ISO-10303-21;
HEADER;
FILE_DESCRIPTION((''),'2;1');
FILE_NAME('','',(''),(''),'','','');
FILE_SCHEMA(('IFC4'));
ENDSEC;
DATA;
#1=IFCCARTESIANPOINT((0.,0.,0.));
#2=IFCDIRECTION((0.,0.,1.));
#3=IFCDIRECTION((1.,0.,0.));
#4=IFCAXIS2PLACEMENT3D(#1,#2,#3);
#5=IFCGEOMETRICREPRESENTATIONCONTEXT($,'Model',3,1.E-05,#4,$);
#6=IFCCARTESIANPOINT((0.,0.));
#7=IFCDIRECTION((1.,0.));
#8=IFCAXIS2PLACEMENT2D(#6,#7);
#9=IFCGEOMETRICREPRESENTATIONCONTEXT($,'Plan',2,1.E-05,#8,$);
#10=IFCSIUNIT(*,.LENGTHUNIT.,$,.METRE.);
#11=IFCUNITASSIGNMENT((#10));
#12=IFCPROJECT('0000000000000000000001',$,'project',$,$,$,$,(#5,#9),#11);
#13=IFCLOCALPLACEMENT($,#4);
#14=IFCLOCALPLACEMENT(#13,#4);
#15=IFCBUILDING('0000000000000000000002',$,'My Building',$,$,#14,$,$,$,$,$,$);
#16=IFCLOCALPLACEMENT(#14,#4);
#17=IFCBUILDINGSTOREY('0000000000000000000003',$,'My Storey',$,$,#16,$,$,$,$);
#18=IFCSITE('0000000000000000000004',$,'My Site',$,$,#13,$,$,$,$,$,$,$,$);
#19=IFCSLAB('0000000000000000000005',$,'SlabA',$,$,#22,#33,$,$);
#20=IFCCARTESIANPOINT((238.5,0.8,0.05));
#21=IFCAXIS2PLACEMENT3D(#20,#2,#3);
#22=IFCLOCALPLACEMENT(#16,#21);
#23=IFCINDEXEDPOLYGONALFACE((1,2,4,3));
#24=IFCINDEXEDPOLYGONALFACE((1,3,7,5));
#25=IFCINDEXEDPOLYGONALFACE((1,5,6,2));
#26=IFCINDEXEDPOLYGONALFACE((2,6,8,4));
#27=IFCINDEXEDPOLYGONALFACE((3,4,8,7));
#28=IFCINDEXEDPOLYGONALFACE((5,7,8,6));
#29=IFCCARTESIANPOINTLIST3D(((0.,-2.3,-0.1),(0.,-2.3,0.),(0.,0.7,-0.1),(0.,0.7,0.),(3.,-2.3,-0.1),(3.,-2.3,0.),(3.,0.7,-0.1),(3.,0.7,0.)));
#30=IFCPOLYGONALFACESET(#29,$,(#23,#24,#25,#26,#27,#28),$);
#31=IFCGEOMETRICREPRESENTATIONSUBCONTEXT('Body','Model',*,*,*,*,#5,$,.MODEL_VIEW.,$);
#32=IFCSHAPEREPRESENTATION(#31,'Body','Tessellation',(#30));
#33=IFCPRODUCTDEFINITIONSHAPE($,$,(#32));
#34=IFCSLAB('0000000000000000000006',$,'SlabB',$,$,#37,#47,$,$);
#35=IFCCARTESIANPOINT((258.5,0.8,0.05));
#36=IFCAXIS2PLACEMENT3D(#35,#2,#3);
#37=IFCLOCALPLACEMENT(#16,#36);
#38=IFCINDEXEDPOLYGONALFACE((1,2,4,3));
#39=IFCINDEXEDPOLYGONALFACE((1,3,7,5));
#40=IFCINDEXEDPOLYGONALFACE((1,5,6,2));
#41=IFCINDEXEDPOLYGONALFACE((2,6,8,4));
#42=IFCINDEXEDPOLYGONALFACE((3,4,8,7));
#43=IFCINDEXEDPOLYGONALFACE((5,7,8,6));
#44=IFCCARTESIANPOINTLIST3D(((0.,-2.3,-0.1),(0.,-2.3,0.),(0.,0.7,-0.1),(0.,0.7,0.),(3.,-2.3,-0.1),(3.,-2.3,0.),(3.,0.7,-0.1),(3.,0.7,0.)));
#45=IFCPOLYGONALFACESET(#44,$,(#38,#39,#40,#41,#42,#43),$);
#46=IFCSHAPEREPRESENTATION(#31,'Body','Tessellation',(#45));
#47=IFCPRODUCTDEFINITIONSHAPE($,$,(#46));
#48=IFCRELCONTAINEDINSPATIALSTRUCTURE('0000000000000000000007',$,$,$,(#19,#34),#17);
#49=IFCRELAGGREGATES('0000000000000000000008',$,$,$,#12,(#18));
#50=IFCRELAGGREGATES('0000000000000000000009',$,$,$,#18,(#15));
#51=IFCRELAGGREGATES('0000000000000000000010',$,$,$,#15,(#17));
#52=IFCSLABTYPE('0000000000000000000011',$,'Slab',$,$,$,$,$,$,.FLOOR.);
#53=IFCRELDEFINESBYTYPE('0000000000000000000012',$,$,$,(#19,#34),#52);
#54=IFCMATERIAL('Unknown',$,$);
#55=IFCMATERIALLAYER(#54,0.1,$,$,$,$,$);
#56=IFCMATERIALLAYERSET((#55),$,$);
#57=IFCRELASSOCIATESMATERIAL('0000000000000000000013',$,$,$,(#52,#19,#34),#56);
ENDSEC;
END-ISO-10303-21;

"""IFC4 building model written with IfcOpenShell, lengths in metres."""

from ifc_helpers import new_model, si_unit, frame, origin_with_axes, origin_2d_with_axis, place, context, subcontext, project, spatial, indexed_curve, outline, extrude, material, layer, layer_set, layer_usage, type_object, element, save


model = new_model("IFC4")

# Units and contexts
model_context = context("Model", 3, precision=1e-05, world=origin_with_axes())
plan_context = context("Plan", 2, precision=1e-05, world=origin_2d_with_axis())
body_context = subcontext(model_context, "Body", "Model", "MODEL_VIEW")
ifc_project = project(units=[si_unit("LENGTHUNIT", "METRE")], contexts=[model_context, plan_context])

# Site, building, storey
site_placement = place(None, origin_with_axes())
site = spatial("IfcSite", under=ifc_project, at=site_placement, Name="My Site")
building_placement = place(site_placement, origin_with_axes())
building = spatial("IfcBuilding", under=site, at=building_placement, Name="My Building")
storey_placement = place(building_placement, origin_with_axes())
storey = spatial("IfcBuildingStorey", under=building, at=storey_placement, Name="My Storey")

# Slabs
ifc_material = material(Name="Unknown")
ifc_layer_1 = layer(ifc_material, 0.1)
ifc_layer_set_1 = layer_set([ifc_layer_1])
ifc_layer_usage_1 = layer_usage(ifc_layer_set_1, "AXIS3", "POSITIVE", -0.1)
slab_type = type_object("IfcSlabType", Name="Slab", PredefinedType="FLOOR", material=ifc_layer_set_1)
slab_1_placement = place(storey_placement, frame((238.5, 0.8, 0.05), z_axis=(0.0, 0.0, 1.0), x_axis=(1.0, 0.0, 0.0)))
element("IfcSlab", 1, at=slab_1_placement, inside=storey, type_object=slab_type, material=ifc_layer_usage_1, Name="SlabA", context=body_context, shape_type="SweptSolid", body=[
    extrude(outline(indexed_curve([(0.0, -2.3), (3.0, -2.3), (3.0, 0.7), (0.0, 0.7), (0.0, -2.3)])), frame((0.0, 0.0, -0.1), z_axis=(0.0, 0.0, 1.0), x_axis=(1.0, 0.0, 0.0)), (0.0, 0.0, 1.0), 0.1),
])
ifc_layer_usage_2 = layer_usage(ifc_layer_set_1, "AXIS3", "POSITIVE", -0.1)
slab_2_placement = place(storey_placement, frame((258.5, 0.8, 0.05), z_axis=(0.0, 0.0, 1.0), x_axis=(1.0, 0.0, 0.0)))
element("IfcSlab", 2, at=slab_2_placement, inside=storey, type_object=slab_type, material=ifc_layer_usage_2, Name="SlabB", context=body_context, shape_type="SweptSolid", body=[
    extrude(outline(indexed_curve([(0.0, -2.3), (3.0, -2.3), (3.0, 0.7), (0.0, 0.7), (0.0, -2.3)])), frame((0.0, 0.0, -0.1), z_axis=(0.0, 0.0, 1.0), x_axis=(1.0, 0.0, 0.0)), (0.0, 0.0, 1.0), 0.1),
])

save(model, "model.ifc")
